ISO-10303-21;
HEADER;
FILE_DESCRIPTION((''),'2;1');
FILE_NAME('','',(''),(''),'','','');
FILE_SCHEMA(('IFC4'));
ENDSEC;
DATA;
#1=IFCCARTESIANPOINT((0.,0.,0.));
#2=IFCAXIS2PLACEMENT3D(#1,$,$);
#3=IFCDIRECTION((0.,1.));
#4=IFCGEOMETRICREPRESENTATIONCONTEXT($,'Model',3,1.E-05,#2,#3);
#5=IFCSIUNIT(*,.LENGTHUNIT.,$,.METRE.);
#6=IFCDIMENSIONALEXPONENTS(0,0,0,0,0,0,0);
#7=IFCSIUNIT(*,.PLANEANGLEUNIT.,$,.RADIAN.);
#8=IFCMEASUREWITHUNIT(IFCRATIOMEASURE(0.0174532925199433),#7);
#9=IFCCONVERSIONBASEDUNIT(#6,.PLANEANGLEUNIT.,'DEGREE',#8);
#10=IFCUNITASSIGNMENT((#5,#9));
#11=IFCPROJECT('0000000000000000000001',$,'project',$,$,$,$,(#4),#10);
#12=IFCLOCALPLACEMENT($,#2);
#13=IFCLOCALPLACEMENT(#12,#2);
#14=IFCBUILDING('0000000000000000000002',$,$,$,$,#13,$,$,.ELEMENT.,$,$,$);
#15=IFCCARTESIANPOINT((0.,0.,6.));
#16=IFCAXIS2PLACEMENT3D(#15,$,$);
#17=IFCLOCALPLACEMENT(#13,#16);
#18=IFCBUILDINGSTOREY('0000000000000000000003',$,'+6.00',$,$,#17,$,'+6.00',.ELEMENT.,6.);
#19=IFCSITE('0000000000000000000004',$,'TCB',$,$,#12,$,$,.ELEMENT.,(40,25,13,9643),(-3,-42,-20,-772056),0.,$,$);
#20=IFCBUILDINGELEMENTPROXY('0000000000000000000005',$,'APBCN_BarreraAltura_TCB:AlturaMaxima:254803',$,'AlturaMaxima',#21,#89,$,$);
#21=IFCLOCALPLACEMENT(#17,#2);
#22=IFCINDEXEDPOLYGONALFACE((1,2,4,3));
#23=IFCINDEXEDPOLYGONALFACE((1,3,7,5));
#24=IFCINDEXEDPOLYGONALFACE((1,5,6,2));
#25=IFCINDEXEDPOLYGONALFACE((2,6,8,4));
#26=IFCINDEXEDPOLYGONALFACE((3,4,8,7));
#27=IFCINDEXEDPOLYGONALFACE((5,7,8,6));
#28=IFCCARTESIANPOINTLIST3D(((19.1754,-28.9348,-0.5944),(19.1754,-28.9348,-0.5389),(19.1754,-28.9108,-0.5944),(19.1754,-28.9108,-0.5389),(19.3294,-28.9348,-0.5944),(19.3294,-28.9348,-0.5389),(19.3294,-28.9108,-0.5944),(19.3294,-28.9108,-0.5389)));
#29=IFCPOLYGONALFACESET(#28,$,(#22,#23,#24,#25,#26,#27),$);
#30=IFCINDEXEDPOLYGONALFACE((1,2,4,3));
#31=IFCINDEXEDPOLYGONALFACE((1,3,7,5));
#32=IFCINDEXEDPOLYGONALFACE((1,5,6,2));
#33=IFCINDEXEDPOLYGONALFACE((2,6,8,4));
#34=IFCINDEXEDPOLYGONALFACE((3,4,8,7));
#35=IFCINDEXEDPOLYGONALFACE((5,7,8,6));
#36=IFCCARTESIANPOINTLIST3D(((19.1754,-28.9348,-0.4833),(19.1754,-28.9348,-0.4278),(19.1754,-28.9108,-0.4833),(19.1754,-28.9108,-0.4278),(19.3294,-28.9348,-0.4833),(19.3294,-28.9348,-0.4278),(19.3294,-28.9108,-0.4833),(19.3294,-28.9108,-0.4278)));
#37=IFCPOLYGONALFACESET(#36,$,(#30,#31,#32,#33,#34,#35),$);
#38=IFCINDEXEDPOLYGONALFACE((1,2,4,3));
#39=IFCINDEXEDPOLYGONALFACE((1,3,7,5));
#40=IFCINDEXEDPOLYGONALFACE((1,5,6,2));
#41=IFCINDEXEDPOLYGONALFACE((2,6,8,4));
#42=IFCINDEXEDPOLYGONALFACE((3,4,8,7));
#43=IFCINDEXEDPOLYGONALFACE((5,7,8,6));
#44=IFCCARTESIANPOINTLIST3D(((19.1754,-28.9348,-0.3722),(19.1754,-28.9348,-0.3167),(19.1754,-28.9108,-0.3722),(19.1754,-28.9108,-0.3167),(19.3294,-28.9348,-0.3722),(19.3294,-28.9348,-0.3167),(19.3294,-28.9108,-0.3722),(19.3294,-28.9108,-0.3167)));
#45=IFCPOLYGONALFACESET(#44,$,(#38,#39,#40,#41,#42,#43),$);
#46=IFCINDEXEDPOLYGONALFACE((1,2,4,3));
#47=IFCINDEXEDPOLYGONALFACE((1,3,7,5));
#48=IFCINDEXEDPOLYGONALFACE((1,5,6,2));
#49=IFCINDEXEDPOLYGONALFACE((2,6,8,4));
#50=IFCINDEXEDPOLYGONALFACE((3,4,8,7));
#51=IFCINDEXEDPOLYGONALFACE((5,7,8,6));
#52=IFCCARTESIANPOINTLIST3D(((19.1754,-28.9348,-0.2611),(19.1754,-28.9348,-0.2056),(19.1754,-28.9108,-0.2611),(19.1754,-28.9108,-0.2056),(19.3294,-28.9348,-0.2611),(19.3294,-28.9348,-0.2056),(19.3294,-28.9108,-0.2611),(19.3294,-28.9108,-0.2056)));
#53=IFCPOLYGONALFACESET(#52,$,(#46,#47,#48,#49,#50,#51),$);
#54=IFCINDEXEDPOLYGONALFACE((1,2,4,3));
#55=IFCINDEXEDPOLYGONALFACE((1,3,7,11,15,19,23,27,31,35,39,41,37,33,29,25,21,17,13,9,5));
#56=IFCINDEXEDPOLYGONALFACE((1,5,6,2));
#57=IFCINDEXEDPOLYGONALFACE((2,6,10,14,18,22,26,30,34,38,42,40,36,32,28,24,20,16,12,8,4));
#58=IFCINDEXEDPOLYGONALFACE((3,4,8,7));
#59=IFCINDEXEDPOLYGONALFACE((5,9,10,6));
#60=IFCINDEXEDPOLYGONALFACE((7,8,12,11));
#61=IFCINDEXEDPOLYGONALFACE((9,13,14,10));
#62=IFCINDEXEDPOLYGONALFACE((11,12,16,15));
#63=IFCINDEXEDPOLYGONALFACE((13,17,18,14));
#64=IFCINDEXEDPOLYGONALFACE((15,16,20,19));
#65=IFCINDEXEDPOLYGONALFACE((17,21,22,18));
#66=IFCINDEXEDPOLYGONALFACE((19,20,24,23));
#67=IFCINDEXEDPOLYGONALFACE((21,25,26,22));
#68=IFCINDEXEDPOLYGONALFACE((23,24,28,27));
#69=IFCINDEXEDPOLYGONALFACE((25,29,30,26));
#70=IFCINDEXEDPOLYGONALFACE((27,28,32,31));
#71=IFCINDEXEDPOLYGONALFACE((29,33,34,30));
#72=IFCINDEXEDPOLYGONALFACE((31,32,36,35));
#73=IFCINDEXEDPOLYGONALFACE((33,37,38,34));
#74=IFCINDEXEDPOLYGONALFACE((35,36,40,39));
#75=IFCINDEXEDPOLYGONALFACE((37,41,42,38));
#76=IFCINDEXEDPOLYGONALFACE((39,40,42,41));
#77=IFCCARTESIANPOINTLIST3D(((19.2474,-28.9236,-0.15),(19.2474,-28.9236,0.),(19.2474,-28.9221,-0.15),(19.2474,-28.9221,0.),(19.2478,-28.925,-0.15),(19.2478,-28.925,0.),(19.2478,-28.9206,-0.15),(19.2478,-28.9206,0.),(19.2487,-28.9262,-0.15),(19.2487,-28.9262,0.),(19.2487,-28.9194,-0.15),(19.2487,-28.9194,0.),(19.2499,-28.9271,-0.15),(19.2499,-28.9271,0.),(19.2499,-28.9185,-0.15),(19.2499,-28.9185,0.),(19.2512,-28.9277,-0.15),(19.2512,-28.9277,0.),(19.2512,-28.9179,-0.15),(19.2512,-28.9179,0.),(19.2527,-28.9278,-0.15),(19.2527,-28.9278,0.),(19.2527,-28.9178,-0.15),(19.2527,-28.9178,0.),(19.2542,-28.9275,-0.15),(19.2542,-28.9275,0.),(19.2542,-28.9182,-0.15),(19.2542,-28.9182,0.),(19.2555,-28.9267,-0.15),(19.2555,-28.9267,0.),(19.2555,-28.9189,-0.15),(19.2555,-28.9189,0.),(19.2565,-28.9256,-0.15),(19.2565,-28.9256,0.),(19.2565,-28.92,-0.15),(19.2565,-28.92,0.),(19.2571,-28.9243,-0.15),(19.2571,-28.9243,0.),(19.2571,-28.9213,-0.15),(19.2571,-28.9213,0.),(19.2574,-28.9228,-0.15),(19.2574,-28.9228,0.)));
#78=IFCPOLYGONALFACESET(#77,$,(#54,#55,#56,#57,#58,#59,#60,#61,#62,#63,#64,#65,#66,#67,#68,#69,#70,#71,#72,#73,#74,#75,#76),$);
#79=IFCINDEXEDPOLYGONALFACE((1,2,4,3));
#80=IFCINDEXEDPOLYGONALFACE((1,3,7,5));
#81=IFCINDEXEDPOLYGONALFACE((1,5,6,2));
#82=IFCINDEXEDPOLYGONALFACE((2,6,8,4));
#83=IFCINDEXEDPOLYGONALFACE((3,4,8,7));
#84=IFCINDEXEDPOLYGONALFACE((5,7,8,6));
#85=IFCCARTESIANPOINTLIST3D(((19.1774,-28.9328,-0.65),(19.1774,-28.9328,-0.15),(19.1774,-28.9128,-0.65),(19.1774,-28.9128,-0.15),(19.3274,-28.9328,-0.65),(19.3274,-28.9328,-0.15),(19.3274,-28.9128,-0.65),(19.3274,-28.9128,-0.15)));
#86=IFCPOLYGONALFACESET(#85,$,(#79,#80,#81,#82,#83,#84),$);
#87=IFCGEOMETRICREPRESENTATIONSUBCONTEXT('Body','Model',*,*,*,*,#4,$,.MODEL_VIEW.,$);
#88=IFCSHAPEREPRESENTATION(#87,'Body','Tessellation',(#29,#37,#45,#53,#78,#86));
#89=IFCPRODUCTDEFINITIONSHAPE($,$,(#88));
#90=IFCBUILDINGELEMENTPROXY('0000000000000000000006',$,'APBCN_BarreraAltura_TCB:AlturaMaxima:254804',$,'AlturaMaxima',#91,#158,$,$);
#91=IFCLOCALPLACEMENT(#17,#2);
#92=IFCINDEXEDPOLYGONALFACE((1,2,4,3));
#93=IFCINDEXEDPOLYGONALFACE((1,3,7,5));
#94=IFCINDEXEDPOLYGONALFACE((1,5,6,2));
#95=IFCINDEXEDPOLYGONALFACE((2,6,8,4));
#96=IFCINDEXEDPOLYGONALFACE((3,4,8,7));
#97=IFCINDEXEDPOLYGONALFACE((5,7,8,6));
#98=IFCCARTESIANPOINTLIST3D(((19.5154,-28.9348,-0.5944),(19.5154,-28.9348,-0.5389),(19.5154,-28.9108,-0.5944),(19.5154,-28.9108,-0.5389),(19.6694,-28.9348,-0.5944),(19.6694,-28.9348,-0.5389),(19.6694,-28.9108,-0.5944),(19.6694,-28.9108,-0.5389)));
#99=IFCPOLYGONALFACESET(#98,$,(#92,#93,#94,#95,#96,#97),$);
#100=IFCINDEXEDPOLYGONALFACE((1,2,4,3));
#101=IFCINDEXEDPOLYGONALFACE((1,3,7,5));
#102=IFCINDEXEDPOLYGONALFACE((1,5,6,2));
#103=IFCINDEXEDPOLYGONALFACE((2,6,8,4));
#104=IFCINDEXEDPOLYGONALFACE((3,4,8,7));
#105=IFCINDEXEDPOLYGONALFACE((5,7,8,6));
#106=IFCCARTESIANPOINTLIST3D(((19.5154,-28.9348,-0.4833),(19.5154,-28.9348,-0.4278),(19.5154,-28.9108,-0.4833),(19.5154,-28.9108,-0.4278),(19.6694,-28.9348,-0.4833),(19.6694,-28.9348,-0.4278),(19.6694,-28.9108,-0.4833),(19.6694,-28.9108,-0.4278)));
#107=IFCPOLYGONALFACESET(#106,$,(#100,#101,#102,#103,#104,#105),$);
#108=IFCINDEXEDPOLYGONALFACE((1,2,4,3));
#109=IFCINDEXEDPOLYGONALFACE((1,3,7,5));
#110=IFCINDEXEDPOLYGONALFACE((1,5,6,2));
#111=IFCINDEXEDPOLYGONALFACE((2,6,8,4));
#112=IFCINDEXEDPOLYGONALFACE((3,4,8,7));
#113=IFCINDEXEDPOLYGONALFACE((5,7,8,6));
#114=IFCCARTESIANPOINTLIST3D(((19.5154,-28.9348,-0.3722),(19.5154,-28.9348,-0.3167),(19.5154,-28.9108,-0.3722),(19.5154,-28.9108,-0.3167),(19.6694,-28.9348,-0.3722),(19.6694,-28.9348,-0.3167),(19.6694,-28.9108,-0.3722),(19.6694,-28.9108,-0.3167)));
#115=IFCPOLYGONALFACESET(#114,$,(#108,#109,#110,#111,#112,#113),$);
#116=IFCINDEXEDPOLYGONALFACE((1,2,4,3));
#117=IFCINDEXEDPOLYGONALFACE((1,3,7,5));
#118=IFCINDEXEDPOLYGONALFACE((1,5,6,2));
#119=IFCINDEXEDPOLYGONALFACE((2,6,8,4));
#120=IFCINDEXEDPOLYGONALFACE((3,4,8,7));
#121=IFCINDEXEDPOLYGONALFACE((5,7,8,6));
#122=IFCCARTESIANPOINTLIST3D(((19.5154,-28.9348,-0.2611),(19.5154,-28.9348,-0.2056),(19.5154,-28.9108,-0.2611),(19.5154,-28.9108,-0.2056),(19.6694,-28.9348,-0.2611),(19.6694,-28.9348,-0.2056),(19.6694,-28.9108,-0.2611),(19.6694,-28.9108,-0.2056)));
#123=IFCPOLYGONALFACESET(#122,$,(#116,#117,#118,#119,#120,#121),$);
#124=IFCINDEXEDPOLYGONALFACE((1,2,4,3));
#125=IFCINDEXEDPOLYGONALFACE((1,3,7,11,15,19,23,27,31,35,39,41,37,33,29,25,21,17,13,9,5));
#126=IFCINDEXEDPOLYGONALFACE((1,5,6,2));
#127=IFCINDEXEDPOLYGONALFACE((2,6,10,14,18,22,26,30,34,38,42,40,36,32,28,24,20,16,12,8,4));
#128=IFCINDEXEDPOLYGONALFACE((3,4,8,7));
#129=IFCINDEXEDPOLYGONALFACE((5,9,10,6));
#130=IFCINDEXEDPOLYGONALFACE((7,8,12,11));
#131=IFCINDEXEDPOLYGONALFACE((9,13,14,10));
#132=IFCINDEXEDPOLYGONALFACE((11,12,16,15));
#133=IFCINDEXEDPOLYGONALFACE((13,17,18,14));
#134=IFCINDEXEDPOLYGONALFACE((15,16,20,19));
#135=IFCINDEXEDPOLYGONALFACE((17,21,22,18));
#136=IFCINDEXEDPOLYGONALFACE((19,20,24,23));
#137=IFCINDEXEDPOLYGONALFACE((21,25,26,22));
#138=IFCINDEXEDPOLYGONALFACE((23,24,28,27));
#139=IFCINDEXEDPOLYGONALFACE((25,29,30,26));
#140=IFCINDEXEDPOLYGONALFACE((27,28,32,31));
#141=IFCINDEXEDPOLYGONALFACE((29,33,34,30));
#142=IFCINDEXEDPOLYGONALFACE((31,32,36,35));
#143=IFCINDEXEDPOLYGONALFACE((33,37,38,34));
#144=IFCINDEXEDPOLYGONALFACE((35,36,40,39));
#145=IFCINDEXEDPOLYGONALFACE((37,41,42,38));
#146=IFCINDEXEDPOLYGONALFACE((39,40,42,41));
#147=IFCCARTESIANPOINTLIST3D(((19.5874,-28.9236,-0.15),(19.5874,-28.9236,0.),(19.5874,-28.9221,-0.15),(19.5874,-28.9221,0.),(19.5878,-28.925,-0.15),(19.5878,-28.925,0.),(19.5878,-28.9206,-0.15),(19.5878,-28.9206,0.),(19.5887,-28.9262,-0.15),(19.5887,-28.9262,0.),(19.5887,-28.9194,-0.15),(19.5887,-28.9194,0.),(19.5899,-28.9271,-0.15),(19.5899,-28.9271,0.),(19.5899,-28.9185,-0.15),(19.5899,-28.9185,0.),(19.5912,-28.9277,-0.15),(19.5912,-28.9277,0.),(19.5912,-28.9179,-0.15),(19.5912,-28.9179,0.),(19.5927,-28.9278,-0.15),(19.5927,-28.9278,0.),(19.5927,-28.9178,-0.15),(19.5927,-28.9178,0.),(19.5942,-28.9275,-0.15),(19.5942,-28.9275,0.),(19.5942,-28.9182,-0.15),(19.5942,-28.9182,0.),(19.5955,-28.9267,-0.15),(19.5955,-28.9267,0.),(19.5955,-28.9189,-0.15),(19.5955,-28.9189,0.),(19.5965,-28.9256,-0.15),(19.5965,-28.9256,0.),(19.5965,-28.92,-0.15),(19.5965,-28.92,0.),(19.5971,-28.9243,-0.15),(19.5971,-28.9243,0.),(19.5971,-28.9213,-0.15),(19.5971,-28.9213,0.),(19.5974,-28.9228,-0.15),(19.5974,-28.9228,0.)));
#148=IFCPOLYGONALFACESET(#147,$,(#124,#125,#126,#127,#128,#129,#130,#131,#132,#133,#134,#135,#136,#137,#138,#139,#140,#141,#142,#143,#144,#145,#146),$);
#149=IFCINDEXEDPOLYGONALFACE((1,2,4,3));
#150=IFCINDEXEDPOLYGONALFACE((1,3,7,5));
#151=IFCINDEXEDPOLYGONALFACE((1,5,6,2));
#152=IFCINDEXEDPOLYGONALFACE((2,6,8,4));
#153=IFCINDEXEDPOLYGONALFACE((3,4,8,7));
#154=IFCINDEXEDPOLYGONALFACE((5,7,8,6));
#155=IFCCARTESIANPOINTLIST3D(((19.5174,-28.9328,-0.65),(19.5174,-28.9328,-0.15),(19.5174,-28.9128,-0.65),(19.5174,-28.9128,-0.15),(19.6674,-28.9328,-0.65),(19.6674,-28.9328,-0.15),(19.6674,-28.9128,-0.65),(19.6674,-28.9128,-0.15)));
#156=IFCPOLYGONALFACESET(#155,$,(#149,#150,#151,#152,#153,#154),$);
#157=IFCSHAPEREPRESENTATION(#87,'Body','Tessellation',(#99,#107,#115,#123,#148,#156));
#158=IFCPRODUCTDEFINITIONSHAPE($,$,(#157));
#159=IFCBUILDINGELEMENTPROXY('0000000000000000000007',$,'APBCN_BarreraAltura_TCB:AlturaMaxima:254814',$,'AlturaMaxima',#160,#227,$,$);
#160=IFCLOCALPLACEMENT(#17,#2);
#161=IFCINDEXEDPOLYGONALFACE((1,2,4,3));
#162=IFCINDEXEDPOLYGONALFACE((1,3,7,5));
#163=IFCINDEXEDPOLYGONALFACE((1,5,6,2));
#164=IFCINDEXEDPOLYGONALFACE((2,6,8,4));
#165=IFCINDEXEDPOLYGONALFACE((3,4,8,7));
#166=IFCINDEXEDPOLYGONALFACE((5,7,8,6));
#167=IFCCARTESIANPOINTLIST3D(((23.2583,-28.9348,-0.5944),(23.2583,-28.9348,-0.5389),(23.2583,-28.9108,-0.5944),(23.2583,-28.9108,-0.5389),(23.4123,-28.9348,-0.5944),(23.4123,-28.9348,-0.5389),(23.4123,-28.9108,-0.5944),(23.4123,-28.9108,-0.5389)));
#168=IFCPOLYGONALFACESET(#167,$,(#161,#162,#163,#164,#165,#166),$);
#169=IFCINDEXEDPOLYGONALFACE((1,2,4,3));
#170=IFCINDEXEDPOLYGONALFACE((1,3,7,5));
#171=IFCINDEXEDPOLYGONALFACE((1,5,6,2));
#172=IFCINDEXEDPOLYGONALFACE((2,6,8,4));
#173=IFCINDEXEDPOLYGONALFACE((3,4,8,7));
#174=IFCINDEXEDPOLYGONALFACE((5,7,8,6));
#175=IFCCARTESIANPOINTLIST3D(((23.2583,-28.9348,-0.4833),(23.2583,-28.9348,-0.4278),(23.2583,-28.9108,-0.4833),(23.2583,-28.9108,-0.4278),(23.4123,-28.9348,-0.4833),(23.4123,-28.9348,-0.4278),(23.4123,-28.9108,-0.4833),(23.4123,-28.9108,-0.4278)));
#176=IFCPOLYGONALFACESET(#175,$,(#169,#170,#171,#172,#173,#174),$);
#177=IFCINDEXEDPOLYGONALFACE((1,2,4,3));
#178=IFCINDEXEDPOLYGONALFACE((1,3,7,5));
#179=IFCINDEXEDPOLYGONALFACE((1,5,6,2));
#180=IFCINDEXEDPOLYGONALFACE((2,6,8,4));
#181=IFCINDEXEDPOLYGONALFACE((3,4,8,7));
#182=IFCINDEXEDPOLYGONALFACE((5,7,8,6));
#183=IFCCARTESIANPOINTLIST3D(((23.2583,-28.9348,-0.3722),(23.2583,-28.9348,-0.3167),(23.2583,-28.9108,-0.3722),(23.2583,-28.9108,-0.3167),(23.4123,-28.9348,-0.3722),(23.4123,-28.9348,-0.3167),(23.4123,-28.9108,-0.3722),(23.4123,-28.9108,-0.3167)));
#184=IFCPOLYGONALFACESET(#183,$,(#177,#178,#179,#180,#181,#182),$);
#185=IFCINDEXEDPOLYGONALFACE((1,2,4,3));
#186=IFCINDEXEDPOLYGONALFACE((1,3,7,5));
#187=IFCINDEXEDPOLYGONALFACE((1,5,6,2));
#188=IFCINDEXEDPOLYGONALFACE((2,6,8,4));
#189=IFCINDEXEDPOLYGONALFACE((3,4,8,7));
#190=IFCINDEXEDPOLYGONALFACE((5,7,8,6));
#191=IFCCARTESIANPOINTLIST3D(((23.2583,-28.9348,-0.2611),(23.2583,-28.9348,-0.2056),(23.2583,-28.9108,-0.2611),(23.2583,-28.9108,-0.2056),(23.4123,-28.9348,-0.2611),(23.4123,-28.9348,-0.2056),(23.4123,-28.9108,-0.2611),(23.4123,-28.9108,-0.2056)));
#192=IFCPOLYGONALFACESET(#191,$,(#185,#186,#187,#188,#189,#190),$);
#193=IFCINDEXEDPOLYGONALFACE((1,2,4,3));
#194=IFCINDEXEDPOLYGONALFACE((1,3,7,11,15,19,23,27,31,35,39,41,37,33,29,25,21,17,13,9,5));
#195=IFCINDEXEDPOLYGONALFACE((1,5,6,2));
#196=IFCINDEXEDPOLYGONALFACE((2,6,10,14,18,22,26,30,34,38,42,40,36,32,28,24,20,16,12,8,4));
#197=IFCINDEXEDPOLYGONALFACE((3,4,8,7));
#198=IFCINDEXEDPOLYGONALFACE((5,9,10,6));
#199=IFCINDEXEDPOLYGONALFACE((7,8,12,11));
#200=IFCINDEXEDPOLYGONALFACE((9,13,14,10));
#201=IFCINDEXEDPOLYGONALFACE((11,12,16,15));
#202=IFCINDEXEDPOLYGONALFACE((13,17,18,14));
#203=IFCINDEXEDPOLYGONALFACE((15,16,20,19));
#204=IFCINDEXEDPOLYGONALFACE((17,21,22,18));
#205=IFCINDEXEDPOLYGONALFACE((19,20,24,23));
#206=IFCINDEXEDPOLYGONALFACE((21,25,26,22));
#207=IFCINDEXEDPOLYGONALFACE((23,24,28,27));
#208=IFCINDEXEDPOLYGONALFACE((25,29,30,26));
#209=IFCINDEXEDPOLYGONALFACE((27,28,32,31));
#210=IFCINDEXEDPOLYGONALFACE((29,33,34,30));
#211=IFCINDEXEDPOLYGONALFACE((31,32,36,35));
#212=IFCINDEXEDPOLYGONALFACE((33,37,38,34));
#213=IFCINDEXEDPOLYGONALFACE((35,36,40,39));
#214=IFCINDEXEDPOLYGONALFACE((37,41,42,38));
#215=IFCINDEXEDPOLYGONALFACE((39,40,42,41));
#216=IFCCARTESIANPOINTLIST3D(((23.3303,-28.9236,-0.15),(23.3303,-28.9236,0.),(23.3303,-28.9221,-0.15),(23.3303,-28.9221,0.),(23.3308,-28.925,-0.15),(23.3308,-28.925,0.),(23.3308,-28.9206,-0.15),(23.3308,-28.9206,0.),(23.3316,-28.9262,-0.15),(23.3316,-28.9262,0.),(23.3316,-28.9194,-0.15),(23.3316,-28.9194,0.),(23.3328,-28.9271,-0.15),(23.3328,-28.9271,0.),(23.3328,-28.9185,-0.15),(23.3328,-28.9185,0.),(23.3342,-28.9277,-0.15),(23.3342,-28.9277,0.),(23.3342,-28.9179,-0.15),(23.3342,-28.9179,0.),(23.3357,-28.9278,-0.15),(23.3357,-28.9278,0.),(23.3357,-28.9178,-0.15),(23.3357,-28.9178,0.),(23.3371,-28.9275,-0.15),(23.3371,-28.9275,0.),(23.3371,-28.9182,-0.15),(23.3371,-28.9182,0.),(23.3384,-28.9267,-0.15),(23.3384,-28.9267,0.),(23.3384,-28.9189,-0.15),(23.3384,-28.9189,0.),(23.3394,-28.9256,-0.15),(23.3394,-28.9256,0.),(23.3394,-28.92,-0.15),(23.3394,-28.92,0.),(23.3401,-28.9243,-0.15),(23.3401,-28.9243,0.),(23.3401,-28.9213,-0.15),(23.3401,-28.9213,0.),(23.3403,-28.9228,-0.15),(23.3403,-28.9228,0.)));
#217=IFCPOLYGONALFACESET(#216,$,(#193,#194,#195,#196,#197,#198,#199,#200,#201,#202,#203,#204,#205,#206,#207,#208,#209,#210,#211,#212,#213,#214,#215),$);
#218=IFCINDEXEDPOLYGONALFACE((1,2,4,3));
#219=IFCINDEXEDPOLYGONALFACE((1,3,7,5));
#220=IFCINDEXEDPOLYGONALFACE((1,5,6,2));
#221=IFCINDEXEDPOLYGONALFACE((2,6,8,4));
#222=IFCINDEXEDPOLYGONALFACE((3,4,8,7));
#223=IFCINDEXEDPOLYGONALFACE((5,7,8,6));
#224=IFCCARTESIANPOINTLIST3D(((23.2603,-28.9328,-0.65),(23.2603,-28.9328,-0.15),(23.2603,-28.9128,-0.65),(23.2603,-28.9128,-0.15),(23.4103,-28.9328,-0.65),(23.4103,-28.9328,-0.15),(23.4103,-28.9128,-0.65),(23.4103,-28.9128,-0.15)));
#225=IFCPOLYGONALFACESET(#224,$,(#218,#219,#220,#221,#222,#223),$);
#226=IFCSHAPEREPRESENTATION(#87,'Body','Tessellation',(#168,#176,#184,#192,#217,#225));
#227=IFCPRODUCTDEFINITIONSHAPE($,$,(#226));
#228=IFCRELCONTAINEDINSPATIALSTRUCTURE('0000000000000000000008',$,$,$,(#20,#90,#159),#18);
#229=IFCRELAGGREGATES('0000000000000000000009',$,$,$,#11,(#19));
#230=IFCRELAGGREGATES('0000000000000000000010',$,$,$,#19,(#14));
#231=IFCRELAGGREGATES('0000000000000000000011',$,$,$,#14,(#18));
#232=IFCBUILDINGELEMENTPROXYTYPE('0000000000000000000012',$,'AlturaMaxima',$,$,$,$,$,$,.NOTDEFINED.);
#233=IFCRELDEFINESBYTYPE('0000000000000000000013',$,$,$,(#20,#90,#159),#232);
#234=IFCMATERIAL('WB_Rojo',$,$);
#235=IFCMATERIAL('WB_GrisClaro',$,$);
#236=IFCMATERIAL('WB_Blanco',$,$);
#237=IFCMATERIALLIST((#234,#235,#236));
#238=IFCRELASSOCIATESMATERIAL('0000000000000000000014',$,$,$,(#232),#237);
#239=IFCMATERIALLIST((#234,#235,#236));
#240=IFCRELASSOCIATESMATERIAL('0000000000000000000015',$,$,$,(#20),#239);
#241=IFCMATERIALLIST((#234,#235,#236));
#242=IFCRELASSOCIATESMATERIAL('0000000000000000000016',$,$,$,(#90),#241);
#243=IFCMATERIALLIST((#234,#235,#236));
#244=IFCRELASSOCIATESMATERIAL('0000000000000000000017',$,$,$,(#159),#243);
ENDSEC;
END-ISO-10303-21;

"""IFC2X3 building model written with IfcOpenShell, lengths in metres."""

from ifc_helpers import new_model, entity, si_unit, converted_unit, direction, frame, frame_2d, origin, origin_2d_with_axis, place, context, subcontext, project, spatial, rectangle, circle, extrude, source, transform, mapped, material, material_list, type_object, type_shapes, element, save


model = new_model("IFC2X3")

# Units and contexts
model_context = context("Model", 3, precision=1e-05, world=origin(), true_north=direction((0.0, 1.0)))
body_context = subcontext(model_context, "Body", "Model", "MODEL_VIEW")
ifc_project = project(units=[si_unit("LENGTHUNIT", "METRE"), converted_unit("PLANEANGLEUNIT", "DEGREE", entity("IfcRatioMeasure", 0.0174532925199433), si_unit("PLANEANGLEUNIT", "RADIAN"), dimensions=[0, 0, 0, 0, 0, 0, 0])], contexts=[model_context])

# Site, building, storey
site_placement = place(None, origin())
site = spatial("IfcSite", under=ifc_project, at=site_placement, Name="TCB", CompositionType="ELEMENT", RefLatitude=(40, 25, 13, 9643), RefLongitude=(-3, -42, -20, -772056), RefElevation=0.0)
building_placement = place(site_placement, origin())
building = spatial("IfcBuilding", under=site, at=building_placement, CompositionType="ELEMENT")
storey_placement = place(building_placement, frame((0.0, 0.0, 6.0)))
storey = spatial("IfcBuildingStorey", under=building, at=storey_placement, Name="+6.00", LongName="+6.00", CompositionType="ELEMENT", Elevation=6.0)

# Building element proxies
ifc_material_1 = material(Name="WB_Rojo")
ifc_material_2 = material(Name="WB_GrisClaro")
ifc_material_3 = material(Name="WB_Blanco")
ifc_material_list_1 = material_list([ifc_material_1, ifc_material_2, ifc_material_3])
building_element_proxy_type = type_object("IfcBuildingElementProxyType", Name="AlturaMaxima", PredefinedType="NOTDEFINED", material=ifc_material_list_1)
shared_shape = source(origin(), body_context, "Body", "SweptSolid", [
    extrude(rectangle(XDim=0.154, YDim=0.024, at=frame_2d((0.0, 0.0), x_axis=(1.0, 0.0))), frame((0.0, 0.0, -0.5944), z_axis=(0.0, 0.0, 1.0), x_axis=(-1.0, 0.0, 0.0)), (0.0, 0.0, 1.0), 0.0556),
    extrude(rectangle(XDim=0.154, YDim=0.024, at=frame_2d((0.0, 0.0), x_axis=(1.0, 0.0))), frame((0.0, 0.0, -0.4833), z_axis=(0.0, 0.0, 1.0), x_axis=(-1.0, 0.0, 0.0)), (0.0, 0.0, 1.0), 0.0556),
    extrude(rectangle(XDim=0.154, YDim=0.024, at=frame_2d((0.0, 0.0), x_axis=(1.0, 0.0))), frame((0.0, 0.0, -0.3722), z_axis=(0.0, 0.0, 1.0), x_axis=(-1.0, 0.0, 0.0)), (0.0, 0.0, 1.0), 0.0556),
    extrude(rectangle(XDim=0.154, YDim=0.024, at=frame_2d((0.0, 0.0), x_axis=(1.0, 0.0))), frame((0.0, 0.0, -0.2611), z_axis=(0.0, 0.0, 1.0), x_axis=(-1.0, 0.0, 0.0)), (0.0, 0.0, 1.0), 0.0556),
    extrude(circle(Radius=0.005, at=frame_2d((0.0, 0.0), x_axis=(1.0, 0.0))), frame((0.0, 0.0, -0.15)), (0.0, 0.0, 1.0), 0.15),
    extrude(rectangle(XDim=0.02, YDim=0.15, at=origin_2d_with_axis()), frame((0.0, 0.0, -0.65), z_axis=(0.0, 0.0, 1.0), x_axis=(0.0, 1.0, 0.0)), (0.0, 0.0, 1.0), 0.5),
])
type_shapes(building_element_proxy_type, [shared_shape])
ifc_material_list_2 = material_list([ifc_material_1, ifc_material_2, ifc_material_3])
proxy_1_placement = place(storey_placement, frame((19.2524, -28.9228, 0.0)))
element("IfcBuildingElementProxy", 1, at=proxy_1_placement, inside=storey, type_object=building_element_proxy_type, material=ifc_material_list_2, Name="APBCN_BarreraAltura_TCB:AlturaMaxima:254803", ObjectType="AlturaMaxima", context=body_context, shape_type="MappedRepresentation", body=[
    mapped(shared_shape, transform((0.0, 0.0, 0.0), scale=1.0)),
])
ifc_material_list_3 = material_list([ifc_material_1, ifc_material_2, ifc_material_3])
proxy_2_placement = place(storey_placement, frame((19.5924, -28.9228, 0.0)))
element("IfcBuildingElementProxy", 2, at=proxy_2_placement, inside=storey, type_object=building_element_proxy_type, material=ifc_material_list_3, Name="APBCN_BarreraAltura_TCB:AlturaMaxima:254804", ObjectType="AlturaMaxima", context=body_context, shape_type="MappedRepresentation", body=[
    mapped(shared_shape, transform((0.0, 0.0, 0.0), scale=1.0)),
])
ifc_material_list_4 = material_list([ifc_material_1, ifc_material_2, ifc_material_3])
proxy_3_placement = place(storey_placement, frame((23.3353, -28.9228, 0.0)))
element("IfcBuildingElementProxy", 3, at=proxy_3_placement, inside=storey, type_object=building_element_proxy_type, material=ifc_material_list_4, Name="APBCN_BarreraAltura_TCB:AlturaMaxima:254814", ObjectType="AlturaMaxima", context=body_context, shape_type="MappedRepresentation", body=[
    mapped(shared_shape, transform((0.0, 0.0, 0.0), scale=1.0)),
])

save(model, "model.ifc")
